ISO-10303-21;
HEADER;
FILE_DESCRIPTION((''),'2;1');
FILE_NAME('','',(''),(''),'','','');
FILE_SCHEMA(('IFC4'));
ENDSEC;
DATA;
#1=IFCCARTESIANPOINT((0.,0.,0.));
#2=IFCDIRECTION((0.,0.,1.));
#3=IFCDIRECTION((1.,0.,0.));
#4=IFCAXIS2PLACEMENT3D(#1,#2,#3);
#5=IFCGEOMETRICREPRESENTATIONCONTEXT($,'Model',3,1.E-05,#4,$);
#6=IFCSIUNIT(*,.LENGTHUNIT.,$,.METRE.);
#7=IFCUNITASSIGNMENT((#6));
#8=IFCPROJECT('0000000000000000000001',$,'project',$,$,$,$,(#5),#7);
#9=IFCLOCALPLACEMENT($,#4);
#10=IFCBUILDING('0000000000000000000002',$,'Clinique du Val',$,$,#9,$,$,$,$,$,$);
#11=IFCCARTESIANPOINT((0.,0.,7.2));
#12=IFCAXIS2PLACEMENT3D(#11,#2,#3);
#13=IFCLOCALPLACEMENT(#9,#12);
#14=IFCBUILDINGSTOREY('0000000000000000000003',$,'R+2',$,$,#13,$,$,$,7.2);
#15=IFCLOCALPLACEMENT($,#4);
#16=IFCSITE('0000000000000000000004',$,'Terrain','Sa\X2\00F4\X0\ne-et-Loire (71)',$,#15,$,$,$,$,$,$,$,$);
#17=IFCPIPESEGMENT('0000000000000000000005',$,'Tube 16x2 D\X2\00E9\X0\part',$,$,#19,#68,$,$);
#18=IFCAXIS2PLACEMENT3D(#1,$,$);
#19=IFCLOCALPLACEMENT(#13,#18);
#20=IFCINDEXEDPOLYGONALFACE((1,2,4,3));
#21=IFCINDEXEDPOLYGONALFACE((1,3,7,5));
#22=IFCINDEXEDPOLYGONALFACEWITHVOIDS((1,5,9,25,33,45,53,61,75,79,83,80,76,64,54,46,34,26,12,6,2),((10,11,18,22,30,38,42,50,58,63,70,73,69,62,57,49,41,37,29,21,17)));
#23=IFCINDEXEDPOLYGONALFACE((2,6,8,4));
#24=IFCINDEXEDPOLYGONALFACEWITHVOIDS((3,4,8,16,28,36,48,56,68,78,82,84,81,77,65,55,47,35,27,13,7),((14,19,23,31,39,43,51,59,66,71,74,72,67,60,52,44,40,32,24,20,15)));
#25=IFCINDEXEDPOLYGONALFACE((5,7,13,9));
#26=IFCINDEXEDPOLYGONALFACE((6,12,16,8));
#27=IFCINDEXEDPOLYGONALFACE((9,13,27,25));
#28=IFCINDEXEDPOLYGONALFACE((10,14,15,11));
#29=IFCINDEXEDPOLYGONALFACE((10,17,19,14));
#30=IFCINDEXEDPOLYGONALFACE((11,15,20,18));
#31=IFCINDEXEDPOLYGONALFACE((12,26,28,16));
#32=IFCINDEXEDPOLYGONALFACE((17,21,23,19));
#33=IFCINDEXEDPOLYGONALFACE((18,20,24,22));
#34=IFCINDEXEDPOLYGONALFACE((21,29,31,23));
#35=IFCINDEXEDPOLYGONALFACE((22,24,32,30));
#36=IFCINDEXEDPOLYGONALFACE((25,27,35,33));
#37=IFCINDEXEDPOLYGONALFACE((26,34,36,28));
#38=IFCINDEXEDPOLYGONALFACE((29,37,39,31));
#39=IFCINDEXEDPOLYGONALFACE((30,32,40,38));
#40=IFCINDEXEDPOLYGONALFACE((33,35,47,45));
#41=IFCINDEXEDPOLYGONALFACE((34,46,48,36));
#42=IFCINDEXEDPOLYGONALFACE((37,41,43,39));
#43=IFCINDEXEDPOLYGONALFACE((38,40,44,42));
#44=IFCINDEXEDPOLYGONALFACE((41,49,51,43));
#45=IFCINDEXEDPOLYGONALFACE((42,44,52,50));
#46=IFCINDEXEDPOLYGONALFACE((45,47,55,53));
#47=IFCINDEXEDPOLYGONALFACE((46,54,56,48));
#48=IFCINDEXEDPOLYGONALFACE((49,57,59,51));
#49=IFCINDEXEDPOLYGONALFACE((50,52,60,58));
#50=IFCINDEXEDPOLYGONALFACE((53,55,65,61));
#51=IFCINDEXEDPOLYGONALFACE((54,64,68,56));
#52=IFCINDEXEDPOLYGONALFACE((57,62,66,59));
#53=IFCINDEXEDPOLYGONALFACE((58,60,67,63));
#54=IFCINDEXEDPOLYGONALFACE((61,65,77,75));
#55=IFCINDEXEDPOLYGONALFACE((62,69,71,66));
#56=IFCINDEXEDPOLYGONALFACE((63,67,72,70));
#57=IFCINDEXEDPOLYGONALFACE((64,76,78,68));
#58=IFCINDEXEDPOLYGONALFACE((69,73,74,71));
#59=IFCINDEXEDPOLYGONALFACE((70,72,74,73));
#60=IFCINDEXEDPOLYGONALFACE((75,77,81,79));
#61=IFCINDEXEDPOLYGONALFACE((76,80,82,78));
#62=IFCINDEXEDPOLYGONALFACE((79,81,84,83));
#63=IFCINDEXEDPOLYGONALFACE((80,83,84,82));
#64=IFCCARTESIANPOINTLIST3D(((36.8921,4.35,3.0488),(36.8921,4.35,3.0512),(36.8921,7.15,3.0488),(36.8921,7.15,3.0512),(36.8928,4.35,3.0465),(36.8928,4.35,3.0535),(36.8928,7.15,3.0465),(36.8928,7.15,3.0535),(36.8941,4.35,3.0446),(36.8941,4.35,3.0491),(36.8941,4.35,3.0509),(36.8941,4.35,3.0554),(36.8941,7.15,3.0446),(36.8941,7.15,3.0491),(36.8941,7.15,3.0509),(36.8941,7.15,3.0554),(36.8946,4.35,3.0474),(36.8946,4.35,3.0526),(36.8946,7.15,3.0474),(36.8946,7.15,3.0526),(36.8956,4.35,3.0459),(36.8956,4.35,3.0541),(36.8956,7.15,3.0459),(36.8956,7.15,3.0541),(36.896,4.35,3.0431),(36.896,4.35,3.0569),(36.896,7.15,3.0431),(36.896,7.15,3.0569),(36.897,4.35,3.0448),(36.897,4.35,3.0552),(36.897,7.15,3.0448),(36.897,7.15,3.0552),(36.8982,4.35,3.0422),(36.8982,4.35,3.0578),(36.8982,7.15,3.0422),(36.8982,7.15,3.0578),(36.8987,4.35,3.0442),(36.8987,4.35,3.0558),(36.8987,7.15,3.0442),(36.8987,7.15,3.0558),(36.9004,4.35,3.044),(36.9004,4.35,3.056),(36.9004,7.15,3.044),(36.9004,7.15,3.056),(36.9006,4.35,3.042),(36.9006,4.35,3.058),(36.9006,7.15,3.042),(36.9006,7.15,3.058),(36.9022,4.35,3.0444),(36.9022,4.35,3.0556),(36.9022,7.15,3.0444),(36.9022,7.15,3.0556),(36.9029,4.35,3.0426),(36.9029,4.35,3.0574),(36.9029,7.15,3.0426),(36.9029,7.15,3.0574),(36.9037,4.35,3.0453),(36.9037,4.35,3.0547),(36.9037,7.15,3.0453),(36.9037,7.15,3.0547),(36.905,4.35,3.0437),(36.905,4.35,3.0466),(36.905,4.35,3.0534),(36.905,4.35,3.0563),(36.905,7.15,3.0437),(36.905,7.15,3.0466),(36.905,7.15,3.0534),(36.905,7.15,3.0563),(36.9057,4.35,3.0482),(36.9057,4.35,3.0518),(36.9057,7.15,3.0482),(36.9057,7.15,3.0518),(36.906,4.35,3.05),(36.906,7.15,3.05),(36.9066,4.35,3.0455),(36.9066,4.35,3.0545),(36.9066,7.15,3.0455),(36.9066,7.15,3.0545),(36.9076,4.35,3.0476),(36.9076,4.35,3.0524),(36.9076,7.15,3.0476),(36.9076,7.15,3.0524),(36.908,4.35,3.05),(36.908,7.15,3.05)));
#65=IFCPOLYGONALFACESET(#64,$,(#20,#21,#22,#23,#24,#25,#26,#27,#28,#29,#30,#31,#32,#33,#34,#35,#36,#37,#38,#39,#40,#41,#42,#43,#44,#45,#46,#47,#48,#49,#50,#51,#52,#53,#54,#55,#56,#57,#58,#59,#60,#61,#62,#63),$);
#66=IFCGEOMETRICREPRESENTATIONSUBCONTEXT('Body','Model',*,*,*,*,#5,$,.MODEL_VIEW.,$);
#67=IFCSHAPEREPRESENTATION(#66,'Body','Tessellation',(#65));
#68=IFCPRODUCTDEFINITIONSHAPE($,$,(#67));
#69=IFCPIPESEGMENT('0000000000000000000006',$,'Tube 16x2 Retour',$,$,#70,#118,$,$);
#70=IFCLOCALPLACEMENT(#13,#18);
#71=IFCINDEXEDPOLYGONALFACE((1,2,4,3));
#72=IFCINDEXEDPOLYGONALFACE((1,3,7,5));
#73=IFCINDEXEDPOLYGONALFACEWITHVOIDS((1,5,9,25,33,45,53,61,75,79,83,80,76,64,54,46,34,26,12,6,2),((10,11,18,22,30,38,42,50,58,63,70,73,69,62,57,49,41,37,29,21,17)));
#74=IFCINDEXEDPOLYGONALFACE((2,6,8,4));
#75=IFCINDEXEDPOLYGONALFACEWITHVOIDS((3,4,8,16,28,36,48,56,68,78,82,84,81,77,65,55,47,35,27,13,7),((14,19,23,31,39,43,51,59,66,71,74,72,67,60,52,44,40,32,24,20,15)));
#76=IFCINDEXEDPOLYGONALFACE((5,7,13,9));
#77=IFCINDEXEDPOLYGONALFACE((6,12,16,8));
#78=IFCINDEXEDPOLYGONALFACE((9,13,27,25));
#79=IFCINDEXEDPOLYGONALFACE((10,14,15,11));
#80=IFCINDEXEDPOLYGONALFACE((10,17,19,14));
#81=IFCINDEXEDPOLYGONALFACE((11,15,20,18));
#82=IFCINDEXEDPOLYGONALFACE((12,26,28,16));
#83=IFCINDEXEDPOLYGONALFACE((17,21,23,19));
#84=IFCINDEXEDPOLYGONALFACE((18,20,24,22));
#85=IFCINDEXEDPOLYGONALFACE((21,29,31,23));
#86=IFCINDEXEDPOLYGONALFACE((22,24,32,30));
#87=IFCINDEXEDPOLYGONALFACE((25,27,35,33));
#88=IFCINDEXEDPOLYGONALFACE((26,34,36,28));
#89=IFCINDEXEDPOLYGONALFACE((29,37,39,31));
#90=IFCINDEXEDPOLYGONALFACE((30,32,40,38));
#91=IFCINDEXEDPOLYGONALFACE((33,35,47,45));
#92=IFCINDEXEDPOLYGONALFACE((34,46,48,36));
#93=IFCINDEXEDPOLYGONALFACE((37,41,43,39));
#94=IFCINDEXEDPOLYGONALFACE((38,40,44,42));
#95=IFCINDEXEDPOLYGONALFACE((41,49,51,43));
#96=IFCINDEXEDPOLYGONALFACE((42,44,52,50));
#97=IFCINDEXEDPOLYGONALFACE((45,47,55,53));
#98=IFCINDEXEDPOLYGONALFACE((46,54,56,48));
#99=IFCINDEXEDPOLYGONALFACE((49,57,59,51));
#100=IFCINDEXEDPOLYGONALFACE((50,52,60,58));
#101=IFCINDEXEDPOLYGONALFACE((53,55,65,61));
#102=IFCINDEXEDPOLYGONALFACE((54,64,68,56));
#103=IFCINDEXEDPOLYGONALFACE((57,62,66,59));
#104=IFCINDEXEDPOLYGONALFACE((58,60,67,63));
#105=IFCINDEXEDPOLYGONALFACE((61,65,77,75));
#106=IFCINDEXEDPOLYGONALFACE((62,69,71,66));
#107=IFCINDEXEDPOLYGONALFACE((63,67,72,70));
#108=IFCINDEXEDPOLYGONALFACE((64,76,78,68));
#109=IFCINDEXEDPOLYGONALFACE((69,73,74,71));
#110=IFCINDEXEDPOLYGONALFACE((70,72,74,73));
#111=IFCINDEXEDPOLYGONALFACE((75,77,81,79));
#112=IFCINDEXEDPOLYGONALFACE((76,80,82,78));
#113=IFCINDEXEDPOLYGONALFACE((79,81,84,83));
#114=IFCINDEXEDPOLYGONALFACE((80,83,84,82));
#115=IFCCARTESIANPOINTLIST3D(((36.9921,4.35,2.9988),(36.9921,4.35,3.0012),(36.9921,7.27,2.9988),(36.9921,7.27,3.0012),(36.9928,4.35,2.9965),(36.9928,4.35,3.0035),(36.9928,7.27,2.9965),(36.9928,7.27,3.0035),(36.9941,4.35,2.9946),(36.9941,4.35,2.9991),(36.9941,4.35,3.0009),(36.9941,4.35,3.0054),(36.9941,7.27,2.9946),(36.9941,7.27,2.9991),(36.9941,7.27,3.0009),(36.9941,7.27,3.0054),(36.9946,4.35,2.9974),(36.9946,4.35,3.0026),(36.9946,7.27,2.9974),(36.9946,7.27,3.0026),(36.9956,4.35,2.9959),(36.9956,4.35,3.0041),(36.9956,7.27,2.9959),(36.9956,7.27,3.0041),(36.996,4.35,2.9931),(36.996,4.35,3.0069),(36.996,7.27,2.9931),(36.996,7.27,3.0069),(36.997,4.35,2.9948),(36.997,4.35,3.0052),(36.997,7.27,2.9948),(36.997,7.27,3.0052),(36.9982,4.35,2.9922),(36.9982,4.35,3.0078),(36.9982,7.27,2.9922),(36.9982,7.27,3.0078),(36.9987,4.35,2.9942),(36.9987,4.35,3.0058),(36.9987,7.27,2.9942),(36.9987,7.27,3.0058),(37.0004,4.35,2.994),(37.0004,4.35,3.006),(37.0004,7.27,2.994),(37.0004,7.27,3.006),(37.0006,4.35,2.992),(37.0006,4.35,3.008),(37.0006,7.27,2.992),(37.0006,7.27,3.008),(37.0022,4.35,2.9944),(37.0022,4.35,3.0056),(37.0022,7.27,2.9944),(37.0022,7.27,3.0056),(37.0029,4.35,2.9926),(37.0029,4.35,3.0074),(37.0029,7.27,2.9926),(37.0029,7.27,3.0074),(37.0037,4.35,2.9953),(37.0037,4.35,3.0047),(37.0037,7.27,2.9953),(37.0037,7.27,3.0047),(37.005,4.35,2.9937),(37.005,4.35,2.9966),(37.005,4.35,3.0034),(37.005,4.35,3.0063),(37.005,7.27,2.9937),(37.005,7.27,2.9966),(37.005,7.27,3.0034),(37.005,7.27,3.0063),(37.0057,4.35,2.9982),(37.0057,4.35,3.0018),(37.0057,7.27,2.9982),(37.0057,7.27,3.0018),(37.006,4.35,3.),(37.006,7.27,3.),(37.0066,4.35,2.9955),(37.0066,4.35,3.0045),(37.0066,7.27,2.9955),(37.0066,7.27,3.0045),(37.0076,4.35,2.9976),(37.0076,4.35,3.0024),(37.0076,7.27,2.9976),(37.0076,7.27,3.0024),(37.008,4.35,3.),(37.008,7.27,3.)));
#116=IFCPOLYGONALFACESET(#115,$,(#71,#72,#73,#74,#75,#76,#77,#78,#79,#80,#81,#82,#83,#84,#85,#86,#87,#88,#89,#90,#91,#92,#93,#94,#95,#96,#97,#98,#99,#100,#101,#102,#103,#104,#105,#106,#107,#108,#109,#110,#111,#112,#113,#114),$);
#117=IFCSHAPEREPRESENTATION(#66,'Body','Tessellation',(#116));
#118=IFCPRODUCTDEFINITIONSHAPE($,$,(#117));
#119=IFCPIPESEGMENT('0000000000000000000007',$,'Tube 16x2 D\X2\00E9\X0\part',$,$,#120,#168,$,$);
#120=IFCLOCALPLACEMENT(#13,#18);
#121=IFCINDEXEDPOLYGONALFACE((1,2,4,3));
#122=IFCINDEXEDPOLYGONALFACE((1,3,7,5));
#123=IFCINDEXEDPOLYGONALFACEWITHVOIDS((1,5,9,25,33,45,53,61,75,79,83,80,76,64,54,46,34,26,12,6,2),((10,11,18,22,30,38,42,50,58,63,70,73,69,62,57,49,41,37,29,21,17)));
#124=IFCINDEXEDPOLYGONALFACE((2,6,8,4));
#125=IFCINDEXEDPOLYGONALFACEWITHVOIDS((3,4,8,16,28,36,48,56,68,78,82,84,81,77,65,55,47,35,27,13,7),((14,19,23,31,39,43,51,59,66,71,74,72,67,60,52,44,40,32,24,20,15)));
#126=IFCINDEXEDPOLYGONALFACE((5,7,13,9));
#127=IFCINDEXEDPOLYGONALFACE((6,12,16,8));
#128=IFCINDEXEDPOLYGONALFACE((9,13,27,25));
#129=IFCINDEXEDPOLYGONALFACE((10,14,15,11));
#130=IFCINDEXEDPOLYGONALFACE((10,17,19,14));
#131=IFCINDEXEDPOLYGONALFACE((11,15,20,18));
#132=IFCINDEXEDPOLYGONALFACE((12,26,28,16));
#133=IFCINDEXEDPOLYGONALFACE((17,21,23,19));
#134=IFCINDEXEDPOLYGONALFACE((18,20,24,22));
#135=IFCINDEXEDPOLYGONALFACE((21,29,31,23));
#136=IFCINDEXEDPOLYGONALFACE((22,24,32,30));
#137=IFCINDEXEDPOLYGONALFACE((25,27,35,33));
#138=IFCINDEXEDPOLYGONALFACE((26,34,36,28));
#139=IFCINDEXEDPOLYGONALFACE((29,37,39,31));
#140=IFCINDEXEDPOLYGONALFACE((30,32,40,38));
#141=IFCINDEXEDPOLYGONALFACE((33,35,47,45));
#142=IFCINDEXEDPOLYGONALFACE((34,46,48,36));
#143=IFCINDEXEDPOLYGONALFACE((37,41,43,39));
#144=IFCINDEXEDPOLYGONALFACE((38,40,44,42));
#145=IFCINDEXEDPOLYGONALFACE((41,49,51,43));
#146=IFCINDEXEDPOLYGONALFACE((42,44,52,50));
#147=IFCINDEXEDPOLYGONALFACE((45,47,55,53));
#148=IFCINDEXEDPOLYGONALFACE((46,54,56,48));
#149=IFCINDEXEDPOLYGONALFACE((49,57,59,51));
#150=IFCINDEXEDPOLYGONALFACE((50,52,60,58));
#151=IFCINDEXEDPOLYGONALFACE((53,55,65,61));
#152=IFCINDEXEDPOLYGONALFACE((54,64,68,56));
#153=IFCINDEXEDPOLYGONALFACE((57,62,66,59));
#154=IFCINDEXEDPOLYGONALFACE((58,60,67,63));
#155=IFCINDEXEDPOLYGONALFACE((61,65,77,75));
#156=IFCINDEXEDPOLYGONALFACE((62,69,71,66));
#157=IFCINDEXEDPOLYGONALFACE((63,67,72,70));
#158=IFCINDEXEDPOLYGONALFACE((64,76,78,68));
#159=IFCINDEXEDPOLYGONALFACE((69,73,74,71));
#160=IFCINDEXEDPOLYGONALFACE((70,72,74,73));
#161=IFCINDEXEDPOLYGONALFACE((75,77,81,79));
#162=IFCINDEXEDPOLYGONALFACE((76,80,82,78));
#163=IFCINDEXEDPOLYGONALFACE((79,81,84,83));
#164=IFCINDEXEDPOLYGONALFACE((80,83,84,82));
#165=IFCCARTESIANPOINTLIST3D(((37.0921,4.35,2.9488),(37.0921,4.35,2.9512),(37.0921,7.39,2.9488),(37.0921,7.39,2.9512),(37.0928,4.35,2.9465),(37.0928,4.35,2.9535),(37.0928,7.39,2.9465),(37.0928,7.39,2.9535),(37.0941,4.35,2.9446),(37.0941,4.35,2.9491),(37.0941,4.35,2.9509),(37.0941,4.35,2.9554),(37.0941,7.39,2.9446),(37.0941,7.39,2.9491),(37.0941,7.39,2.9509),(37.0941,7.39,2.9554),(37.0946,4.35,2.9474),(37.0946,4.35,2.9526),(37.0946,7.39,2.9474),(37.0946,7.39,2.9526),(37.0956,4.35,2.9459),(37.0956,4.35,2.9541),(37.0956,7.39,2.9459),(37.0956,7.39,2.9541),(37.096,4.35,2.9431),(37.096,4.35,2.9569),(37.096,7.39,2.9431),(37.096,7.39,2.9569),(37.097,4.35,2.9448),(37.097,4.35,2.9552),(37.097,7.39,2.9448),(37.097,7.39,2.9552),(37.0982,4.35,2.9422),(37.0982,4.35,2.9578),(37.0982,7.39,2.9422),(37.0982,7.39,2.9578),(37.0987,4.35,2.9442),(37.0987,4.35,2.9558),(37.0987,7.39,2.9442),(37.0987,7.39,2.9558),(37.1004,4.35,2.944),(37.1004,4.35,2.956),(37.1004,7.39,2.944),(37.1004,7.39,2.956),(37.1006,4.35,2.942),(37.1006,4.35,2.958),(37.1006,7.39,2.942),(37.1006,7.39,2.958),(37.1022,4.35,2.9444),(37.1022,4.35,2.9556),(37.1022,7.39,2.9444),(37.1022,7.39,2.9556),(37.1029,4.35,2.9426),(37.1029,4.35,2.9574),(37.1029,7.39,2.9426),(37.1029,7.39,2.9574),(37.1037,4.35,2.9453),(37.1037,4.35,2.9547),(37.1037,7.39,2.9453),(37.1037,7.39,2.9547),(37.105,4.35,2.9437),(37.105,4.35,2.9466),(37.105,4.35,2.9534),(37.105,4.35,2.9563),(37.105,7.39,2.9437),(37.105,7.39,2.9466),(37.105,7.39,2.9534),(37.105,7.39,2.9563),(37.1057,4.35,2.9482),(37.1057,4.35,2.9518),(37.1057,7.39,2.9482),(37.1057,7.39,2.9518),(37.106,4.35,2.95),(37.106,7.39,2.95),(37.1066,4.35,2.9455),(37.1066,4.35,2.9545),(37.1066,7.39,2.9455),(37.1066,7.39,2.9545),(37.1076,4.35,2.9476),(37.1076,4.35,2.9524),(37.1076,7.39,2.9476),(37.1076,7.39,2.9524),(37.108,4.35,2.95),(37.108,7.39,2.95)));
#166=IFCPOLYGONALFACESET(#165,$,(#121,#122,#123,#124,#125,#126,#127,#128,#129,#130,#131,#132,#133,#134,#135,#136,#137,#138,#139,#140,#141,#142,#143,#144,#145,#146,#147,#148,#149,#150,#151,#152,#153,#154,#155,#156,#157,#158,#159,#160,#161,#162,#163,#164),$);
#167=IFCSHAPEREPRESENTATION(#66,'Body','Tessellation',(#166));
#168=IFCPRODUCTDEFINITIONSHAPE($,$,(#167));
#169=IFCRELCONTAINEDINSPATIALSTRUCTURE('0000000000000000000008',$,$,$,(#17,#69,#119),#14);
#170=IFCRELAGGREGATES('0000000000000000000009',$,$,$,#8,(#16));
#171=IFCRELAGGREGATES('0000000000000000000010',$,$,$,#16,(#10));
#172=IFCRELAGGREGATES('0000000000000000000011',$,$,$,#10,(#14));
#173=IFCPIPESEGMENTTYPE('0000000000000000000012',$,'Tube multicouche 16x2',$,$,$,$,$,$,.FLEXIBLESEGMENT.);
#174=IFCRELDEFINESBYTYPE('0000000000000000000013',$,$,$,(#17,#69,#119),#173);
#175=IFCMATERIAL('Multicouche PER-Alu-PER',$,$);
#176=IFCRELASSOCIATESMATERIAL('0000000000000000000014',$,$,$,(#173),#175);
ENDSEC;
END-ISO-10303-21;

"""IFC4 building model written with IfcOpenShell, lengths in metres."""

from ifc_helpers import new_model, si_unit, frame, origin_with_axes, place, context, subcontext, project, spatial, hollow_circle, extrude, material, type_object, element, save


model = new_model("IFC4")

# Units and contexts
model_context = context("Model", 3, precision=1e-05, world=origin_with_axes())
body_context = subcontext(model_context, "Body", "Model", "MODEL_VIEW")
ifc_project = project(units=[si_unit("LENGTHUNIT", "METRE")], contexts=[model_context])

# Site, building, storey
site_placement = place(None, origin_with_axes())
site = spatial("IfcSite", under=ifc_project, at=site_placement, Name="Terrain", Description="Saône-et-Loire (71)")
building_placement = place(None, origin_with_axes())
building = spatial("IfcBuilding", under=site, at=building_placement, Name="Clinique du Val")
storey_placement = place(building_placement, frame((0.0, 0.0, 7.2), z_axis=(0.0, 0.0, 1.0), x_axis=(1.0, 0.0, 0.0)))
storey = spatial("IfcBuildingStorey", under=building, at=storey_placement, Name="R+2", Elevation=7.2)

# Pipe segments
ifc_material_1 = material(Name="Multicouche PER-Alu-PER")
pipe_segment_type_1 = type_object("IfcPipeSegmentType", Name="Tube multicouche 16x2", PredefinedType="FLEXIBLESEGMENT", material=ifc_material_1)
pipe_segment_1_placement = place(storey_placement, frame((36.9, 7.15, 3.05), z_axis=(0.0, -1.0, 0.0), x_axis=(1.0, 0.0, 0.0)))
element("IfcPipeSegment", 1, at=pipe_segment_1_placement, inside=storey, type_object=pipe_segment_type_1, Name="Tube 16x2 Départ", context=body_context, shape_type="SweptSolid", body=[
    extrude(hollow_circle(Radius=0.008, WallThickness=0.002), origin_with_axes(), (0.0, 0.0, 1.0), 2.8),
])
pipe_segment_2_placement = place(storey_placement, frame((37.0, 7.27, 3.0), z_axis=(0.0, -1.0, 0.0), x_axis=(1.0, 0.0, 0.0)))
element("IfcPipeSegment", 2, at=pipe_segment_2_placement, inside=storey, type_object=pipe_segment_type_1, Name="Tube 16x2 Retour", context=body_context, shape_type="SweptSolid", body=[
    extrude(hollow_circle(Radius=0.008, WallThickness=0.002), origin_with_axes(), (0.0, 0.0, 1.0), 2.92),
])
pipe_segment_3_placement = place(storey_placement, frame((37.1, 7.39, 2.95), z_axis=(0.0, -1.0, 0.0), x_axis=(1.0, 0.0, 0.0)))
element("IfcPipeSegment", 3, at=pipe_segment_3_placement, inside=storey, type_object=pipe_segment_type_1, Name="Tube 16x2 Départ", context=body_context, shape_type="SweptSolid", body=[
    extrude(hollow_circle(Radius=0.008, WallThickness=0.002), origin_with_axes(), (0.0, 0.0, 1.0), 3.04),
])

save(model, "model.ifc")
